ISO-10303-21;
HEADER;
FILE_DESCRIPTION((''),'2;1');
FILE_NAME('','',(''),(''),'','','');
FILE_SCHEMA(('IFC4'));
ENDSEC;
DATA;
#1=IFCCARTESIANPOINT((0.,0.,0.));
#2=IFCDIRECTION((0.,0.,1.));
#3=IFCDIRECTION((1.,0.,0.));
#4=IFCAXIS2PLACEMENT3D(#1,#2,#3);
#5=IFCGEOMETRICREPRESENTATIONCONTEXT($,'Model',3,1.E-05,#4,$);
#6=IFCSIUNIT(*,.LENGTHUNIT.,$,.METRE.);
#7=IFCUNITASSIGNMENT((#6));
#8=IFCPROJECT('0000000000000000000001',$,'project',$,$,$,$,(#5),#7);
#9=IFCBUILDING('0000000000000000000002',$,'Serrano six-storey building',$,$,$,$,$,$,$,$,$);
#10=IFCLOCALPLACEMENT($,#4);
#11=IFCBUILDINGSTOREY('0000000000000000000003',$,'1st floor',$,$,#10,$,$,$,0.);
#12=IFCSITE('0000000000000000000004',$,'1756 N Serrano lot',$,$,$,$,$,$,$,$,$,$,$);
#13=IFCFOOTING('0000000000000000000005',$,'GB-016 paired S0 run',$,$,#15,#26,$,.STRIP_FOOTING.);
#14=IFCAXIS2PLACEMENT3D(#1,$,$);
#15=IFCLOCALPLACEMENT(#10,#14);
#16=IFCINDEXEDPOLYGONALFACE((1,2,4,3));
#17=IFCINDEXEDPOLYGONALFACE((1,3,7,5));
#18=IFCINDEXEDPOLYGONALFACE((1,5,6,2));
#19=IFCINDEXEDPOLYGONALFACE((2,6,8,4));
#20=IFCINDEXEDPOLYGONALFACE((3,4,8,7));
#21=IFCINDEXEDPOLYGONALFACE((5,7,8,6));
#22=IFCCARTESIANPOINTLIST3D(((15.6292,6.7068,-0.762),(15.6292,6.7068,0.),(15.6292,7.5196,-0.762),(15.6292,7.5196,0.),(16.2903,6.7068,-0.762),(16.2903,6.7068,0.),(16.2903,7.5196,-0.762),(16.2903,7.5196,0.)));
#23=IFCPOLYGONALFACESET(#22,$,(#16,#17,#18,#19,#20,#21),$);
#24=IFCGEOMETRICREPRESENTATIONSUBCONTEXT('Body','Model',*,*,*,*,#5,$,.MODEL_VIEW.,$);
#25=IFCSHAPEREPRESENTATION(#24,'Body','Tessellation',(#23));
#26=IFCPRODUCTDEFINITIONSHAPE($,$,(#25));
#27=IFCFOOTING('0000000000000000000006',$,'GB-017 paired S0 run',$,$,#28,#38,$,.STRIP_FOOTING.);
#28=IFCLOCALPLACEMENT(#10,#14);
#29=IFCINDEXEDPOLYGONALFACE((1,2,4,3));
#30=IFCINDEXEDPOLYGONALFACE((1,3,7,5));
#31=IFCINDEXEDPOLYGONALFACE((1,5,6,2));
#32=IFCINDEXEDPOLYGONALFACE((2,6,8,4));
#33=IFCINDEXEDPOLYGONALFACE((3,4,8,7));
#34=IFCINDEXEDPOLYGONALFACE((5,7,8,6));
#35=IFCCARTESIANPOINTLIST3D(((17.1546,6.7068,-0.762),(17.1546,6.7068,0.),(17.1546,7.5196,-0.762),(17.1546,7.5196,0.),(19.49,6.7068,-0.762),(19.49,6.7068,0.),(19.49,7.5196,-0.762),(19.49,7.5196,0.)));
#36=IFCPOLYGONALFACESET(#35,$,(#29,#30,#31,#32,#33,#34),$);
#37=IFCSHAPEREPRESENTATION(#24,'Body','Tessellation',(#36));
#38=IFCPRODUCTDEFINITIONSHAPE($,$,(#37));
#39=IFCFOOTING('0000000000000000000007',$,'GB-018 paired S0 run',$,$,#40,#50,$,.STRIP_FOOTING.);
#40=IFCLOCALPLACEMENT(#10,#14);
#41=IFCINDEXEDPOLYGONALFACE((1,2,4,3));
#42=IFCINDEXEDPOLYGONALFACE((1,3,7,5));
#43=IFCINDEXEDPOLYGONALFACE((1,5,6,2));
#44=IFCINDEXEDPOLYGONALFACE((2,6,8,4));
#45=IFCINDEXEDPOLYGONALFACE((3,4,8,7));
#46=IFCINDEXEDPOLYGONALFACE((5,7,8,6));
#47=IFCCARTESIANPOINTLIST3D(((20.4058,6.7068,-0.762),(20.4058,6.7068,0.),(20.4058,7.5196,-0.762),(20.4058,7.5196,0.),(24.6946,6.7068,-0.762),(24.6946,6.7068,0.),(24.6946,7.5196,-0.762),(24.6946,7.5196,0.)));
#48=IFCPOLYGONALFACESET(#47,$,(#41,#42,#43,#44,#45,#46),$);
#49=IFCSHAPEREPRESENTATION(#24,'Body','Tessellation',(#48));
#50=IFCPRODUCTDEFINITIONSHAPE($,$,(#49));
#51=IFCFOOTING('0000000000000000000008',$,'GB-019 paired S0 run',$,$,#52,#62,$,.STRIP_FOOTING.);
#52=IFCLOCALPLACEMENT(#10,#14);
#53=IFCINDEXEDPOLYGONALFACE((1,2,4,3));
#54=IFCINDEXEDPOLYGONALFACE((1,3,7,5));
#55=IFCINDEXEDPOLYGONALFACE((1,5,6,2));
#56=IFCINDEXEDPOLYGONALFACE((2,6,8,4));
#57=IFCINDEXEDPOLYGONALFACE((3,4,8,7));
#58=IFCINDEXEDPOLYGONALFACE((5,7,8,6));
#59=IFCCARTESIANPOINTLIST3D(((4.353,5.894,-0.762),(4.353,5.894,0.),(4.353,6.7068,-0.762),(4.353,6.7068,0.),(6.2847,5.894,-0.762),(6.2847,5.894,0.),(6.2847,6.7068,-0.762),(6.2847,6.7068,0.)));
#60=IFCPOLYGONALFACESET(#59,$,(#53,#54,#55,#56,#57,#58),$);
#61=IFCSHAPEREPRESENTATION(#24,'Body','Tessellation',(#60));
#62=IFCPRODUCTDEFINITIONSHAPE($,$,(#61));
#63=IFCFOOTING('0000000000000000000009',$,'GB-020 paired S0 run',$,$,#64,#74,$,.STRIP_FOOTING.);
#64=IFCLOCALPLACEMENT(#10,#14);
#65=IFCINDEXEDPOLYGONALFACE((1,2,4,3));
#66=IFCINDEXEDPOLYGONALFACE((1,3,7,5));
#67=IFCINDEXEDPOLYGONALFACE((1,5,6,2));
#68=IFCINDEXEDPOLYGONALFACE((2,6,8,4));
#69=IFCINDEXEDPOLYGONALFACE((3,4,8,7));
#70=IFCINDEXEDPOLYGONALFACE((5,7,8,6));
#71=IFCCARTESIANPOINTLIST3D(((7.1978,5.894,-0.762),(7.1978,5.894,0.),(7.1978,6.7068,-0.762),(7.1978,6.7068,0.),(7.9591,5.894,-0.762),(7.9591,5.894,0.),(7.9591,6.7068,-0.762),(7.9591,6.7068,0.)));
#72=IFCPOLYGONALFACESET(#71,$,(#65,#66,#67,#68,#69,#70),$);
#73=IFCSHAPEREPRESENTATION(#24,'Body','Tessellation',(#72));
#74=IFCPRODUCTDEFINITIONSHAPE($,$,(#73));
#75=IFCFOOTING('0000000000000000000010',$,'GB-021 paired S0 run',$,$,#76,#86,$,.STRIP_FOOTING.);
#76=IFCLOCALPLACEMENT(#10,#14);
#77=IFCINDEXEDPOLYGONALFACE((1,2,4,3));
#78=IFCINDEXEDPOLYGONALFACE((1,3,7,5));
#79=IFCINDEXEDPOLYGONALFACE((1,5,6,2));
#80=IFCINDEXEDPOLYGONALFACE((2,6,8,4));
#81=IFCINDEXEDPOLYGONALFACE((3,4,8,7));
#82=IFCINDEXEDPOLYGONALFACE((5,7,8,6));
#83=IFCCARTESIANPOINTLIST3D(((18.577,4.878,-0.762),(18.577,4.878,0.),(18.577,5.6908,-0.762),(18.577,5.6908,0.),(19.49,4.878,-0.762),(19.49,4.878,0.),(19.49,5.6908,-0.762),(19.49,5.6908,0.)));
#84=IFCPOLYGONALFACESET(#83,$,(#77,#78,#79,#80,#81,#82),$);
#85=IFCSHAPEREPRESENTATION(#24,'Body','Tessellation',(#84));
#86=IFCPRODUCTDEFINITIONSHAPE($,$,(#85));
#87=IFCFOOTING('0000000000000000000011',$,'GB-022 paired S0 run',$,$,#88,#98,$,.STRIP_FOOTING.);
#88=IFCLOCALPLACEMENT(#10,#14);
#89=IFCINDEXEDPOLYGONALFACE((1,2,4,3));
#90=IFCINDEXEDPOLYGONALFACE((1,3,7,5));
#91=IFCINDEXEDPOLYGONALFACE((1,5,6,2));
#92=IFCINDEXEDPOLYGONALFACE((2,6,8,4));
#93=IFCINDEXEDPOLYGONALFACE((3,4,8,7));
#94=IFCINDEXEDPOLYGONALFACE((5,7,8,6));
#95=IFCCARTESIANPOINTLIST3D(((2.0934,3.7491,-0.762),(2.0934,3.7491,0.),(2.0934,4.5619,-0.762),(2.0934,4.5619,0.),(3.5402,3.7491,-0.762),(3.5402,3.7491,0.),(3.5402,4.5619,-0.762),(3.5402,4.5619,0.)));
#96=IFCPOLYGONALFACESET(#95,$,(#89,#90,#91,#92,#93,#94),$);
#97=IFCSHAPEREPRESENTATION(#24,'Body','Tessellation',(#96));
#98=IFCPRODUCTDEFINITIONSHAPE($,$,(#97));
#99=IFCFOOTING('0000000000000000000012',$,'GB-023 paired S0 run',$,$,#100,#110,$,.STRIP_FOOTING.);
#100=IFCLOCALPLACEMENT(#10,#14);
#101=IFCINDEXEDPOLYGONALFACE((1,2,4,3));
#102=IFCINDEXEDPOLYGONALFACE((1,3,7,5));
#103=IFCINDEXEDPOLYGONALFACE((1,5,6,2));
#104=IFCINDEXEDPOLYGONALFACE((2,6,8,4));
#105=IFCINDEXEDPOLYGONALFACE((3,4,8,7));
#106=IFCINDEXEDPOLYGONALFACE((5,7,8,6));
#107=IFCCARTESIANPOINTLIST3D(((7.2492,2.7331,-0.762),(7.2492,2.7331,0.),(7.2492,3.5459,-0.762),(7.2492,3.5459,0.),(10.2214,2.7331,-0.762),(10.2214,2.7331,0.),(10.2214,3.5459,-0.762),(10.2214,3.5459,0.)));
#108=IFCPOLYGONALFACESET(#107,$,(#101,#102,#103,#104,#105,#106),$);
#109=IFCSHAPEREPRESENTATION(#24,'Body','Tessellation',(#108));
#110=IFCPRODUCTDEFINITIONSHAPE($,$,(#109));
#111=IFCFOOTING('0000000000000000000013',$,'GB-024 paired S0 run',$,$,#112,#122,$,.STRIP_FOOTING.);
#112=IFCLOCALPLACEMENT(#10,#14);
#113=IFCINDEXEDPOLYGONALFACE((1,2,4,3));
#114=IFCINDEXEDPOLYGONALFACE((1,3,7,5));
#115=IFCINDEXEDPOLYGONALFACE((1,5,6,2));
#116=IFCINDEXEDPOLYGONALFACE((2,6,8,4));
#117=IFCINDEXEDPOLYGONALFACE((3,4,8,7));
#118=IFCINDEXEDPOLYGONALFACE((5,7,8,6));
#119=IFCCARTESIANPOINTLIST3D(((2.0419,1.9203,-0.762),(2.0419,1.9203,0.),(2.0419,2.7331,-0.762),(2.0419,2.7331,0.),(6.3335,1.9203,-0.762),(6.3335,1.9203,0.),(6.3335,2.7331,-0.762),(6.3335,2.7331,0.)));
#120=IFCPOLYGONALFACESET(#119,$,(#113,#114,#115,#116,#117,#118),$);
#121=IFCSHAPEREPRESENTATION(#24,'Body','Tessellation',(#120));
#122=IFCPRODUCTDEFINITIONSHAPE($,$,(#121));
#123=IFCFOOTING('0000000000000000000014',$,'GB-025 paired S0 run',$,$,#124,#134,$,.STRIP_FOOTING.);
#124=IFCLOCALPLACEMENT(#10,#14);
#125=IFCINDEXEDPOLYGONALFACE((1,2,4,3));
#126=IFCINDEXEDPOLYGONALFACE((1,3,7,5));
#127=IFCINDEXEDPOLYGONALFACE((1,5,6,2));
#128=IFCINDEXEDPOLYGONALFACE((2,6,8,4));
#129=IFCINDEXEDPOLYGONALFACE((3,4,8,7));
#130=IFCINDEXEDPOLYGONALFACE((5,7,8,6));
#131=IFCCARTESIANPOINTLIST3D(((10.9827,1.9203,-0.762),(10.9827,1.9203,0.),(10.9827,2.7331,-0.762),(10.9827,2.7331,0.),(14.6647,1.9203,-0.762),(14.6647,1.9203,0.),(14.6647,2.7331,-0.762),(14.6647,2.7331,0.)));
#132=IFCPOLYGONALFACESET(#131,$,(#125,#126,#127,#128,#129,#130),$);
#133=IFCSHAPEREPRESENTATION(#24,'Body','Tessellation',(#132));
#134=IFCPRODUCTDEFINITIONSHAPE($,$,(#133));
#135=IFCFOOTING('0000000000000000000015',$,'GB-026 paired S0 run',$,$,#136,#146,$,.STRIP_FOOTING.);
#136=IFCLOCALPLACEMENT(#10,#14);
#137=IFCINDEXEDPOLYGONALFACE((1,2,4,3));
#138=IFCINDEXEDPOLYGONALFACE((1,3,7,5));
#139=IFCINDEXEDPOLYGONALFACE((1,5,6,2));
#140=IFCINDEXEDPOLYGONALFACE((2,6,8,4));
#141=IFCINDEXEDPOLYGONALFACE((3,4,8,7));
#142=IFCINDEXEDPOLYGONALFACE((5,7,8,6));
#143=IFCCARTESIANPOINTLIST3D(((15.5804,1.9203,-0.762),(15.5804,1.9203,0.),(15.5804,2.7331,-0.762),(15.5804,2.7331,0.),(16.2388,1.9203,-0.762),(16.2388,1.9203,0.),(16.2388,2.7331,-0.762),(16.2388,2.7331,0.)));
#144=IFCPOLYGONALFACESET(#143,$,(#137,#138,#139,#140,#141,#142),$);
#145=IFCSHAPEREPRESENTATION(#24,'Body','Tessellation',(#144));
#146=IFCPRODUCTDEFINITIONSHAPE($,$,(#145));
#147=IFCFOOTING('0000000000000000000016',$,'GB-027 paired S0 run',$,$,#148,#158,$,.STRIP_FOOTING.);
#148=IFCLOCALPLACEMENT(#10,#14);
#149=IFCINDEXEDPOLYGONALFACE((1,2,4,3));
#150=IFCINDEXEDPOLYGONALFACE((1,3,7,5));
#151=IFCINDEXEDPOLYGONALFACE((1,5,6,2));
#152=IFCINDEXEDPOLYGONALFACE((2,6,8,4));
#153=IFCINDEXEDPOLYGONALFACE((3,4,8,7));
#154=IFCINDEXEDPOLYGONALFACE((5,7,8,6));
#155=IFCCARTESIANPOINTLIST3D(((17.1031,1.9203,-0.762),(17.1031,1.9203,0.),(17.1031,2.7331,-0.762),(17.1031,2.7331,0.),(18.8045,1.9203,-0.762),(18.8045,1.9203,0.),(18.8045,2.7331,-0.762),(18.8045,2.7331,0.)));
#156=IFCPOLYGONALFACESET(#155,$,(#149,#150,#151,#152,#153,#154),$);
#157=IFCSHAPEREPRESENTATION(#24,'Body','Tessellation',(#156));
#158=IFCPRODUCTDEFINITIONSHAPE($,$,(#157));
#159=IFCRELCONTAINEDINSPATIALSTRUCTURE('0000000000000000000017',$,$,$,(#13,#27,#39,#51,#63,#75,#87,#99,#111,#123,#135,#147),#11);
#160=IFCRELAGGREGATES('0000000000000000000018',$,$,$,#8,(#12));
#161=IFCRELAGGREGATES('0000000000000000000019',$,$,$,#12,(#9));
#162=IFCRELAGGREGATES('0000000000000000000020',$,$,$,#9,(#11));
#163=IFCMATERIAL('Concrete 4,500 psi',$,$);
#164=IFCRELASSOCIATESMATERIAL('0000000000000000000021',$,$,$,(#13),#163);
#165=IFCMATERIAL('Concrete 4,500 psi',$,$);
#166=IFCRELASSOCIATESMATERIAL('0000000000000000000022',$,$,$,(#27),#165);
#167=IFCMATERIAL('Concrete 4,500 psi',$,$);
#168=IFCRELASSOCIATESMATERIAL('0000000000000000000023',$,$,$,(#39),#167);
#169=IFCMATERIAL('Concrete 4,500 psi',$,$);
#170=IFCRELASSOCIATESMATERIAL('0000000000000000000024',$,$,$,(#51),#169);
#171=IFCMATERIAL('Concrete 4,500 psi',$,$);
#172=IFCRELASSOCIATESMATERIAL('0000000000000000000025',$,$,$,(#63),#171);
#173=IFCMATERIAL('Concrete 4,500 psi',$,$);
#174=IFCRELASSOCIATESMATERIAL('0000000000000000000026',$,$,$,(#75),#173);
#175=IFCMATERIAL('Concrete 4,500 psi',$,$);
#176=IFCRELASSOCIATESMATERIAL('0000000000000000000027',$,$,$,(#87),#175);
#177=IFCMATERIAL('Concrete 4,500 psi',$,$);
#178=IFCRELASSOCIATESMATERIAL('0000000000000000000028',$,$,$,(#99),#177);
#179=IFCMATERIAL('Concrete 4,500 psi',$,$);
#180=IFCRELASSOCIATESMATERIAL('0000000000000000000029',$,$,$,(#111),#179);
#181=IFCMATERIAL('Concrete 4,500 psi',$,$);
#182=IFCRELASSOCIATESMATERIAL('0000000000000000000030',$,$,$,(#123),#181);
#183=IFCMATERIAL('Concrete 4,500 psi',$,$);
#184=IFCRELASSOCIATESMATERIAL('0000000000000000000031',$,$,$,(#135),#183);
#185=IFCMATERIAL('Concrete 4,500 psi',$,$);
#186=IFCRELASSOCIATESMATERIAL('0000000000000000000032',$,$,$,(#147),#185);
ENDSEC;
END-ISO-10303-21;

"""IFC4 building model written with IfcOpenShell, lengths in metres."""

from ifc_helpers import new_model, si_unit, frame, origin_with_axes, place, context, subcontext, project, spatial, polyline, outline, extrude, material, element, save


model = new_model("IFC4")

# Units and contexts
model_context = context("Model", 3, precision=1e-05, world=origin_with_axes())
body_context = subcontext(model_context, "Body", "Model", "MODEL_VIEW")
ifc_project = project(units=[si_unit("LENGTHUNIT", "METRE")], contexts=[model_context])

# Site, building, storey
site = spatial("IfcSite", under=ifc_project, Name="1756 N Serrano lot")
building = spatial("IfcBuilding", under=site, Name="Serrano six-storey building")
storey_placement = place(None, origin_with_axes())
storey = spatial("IfcBuildingStorey", under=building, at=storey_placement, Name="1st floor", Elevation=0.0)

# Footings
ifc_material_1 = material(Name="Concrete 4,500 psi")
footing_1_placement = place(storey_placement, origin_with_axes())
element("IfcFooting", 1, at=footing_1_placement, inside=storey, material=ifc_material_1, Name="GB-016 paired S0 run", PredefinedType="STRIP_FOOTING", context=body_context, shape_type="SweptSolid", body=[
    extrude(outline(polyline([(16.2903, 7.5196), (16.2903, 6.7068), (15.6292, 6.7068), (15.6292, 7.5196), (16.2903, 7.5196)])), frame((0.0, 0.0, -0.762)), (0.0, 0.0, 1.0), 0.762),
])
ifc_material_2 = material(Name="Concrete 4,500 psi")
footing_2_placement = place(storey_placement, origin_with_axes())
element("IfcFooting", 2, at=footing_2_placement, inside=storey, material=ifc_material_2, Name="GB-017 paired S0 run", PredefinedType="STRIP_FOOTING", context=body_context, shape_type="SweptSolid", body=[
    extrude(outline(polyline([(19.49, 7.5196), (19.49, 6.7068), (17.1546, 6.7068), (17.1546, 7.5196), (19.49, 7.5196)])), frame((0.0, 0.0, -0.762)), (0.0, 0.0, 1.0), 0.762),
])
ifc_material_3 = material(Name="Concrete 4,500 psi")
footing_3_placement = place(storey_placement, origin_with_axes())
element("IfcFooting", 3, at=footing_3_placement, inside=storey, material=ifc_material_3, Name="GB-018 paired S0 run", PredefinedType="STRIP_FOOTING", context=body_context, shape_type="SweptSolid", body=[
    extrude(outline(polyline([(24.6946, 7.5196), (24.6946, 6.7068), (20.4058, 6.7068), (20.4058, 7.5196), (24.6946, 7.5196)])), frame((0.0, 0.0, -0.762)), (0.0, 0.0, 1.0), 0.762),
])
ifc_material_4 = material(Name="Concrete 4,500 psi")
footing_4_placement = place(storey_placement, origin_with_axes())
element("IfcFooting", 4, at=footing_4_placement, inside=storey, material=ifc_material_4, Name="GB-019 paired S0 run", PredefinedType="STRIP_FOOTING", context=body_context, shape_type="SweptSolid", body=[
    extrude(outline(polyline([(6.2847, 6.7068), (6.2847, 5.894), (4.353, 5.894), (4.353, 6.7068), (6.2847, 6.7068)])), frame((0.0, 0.0, -0.762)), (0.0, 0.0, 1.0), 0.762),
])
ifc_material_5 = material(Name="Concrete 4,500 psi")
footing_5_placement = place(storey_placement, origin_with_axes())
element("IfcFooting", 5, at=footing_5_placement, inside=storey, material=ifc_material_5, Name="GB-020 paired S0 run", PredefinedType="STRIP_FOOTING", context=body_context, shape_type="SweptSolid", body=[
    extrude(outline(polyline([(7.9591, 6.7068), (7.9591, 5.894), (7.1978, 5.894), (7.1978, 6.7068), (7.9591, 6.7068)])), frame((0.0, 0.0, -0.762)), (0.0, 0.0, 1.0), 0.762),
])
ifc_material_6 = material(Name="Concrete 4,500 psi")
footing_6_placement = place(storey_placement, origin_with_axes())
element("IfcFooting", 6, at=footing_6_placement, inside=storey, material=ifc_material_6, Name="GB-021 paired S0 run", PredefinedType="STRIP_FOOTING", context=body_context, shape_type="SweptSolid", body=[
    extrude(outline(polyline([(19.49, 5.6908), (19.49, 4.878), (18.577, 4.878), (18.577, 5.6908), (19.49, 5.6908)])), frame((0.0, 0.0, -0.762)), (0.0, 0.0, 1.0), 0.762),
])
ifc_material_7 = material(Name="Concrete 4,500 psi")
footing_7_placement = place(storey_placement, origin_with_axes())
element("IfcFooting", 7, at=footing_7_placement, inside=storey, material=ifc_material_7, Name="GB-022 paired S0 run", PredefinedType="STRIP_FOOTING", context=body_context, shape_type="SweptSolid", body=[
    extrude(outline(polyline([(3.5402, 4.5619), (3.5402, 3.7491), (2.0934, 3.7491), (2.0934, 4.5619), (3.5402, 4.5619)])), frame((0.0, 0.0, -0.762)), (0.0, 0.0, 1.0), 0.762),
])
ifc_material_8 = material(Name="Concrete 4,500 psi")
footing_8_placement = place(storey_placement, origin_with_axes())
element("IfcFooting", 8, at=footing_8_placement, inside=storey, material=ifc_material_8, Name="GB-023 paired S0 run", PredefinedType="STRIP_FOOTING", context=body_context, shape_type="SweptSolid", body=[
    extrude(outline(polyline([(10.2214, 3.5459), (10.2214, 2.7331), (7.2492, 2.7331), (7.2492, 3.5459), (10.2214, 3.5459)])), frame((0.0, 0.0, -0.762)), (0.0, 0.0, 1.0), 0.762),
])
ifc_material_9 = material(Name="Concrete 4,500 psi")
footing_9_placement = place(storey_placement, origin_with_axes())
element("IfcFooting", 9, at=footing_9_placement, inside=storey, material=ifc_material_9, Name="GB-024 paired S0 run", PredefinedType="STRIP_FOOTING", context=body_context, shape_type="SweptSolid", body=[
    extrude(outline(polyline([(6.3335, 2.7331), (6.3335, 1.9203), (2.0419, 1.9203), (2.0419, 2.7331), (6.3335, 2.7331)])), frame((0.0, 0.0, -0.762)), (0.0, 0.0, 1.0), 0.762),
])
ifc_material_10 = material(Name="Concrete 4,500 psi")
footing_10_placement = place(storey_placement, origin_with_axes())
element("IfcFooting", 10, at=footing_10_placement, inside=storey, material=ifc_material_10, Name="GB-025 paired S0 run", PredefinedType="STRIP_FOOTING", context=body_context, shape_type="SweptSolid", body=[
    extrude(outline(polyline([(14.6647, 2.7331), (14.6647, 1.9203), (10.9827, 1.9203), (10.9827, 2.7331), (14.6647, 2.7331)])), frame((0.0, 0.0, -0.762)), (0.0, 0.0, 1.0), 0.762),
])
ifc_material_11 = material(Name="Concrete 4,500 psi")
footing_11_placement = place(storey_placement, origin_with_axes())
element("IfcFooting", 11, at=footing_11_placement, inside=storey, material=ifc_material_11, Name="GB-026 paired S0 run", PredefinedType="STRIP_FOOTING", context=body_context, shape_type="SweptSolid", body=[
    extrude(outline(polyline([(16.2388, 2.7331), (16.2388, 1.9203), (15.5804, 1.9203), (15.5804, 2.7331), (16.2388, 2.7331)])), frame((0.0, 0.0, -0.762)), (0.0, 0.0, 1.0), 0.762),
])
ifc_material_12 = material(Name="Concrete 4,500 psi")
footing_12_placement = place(storey_placement, origin_with_axes())
element("IfcFooting", 12, at=footing_12_placement, inside=storey, material=ifc_material_12, Name="GB-027 paired S0 run", PredefinedType="STRIP_FOOTING", context=body_context, shape_type="SweptSolid", body=[
    extrude(outline(polyline([(18.8045, 2.7331), (18.8045, 1.9203), (17.1031, 1.9203), (17.1031, 2.7331), (18.8045, 2.7331)])), frame((0.0, 0.0, -0.762)), (0.0, 0.0, 1.0), 0.762),
])

save(model, "model.ifc")
